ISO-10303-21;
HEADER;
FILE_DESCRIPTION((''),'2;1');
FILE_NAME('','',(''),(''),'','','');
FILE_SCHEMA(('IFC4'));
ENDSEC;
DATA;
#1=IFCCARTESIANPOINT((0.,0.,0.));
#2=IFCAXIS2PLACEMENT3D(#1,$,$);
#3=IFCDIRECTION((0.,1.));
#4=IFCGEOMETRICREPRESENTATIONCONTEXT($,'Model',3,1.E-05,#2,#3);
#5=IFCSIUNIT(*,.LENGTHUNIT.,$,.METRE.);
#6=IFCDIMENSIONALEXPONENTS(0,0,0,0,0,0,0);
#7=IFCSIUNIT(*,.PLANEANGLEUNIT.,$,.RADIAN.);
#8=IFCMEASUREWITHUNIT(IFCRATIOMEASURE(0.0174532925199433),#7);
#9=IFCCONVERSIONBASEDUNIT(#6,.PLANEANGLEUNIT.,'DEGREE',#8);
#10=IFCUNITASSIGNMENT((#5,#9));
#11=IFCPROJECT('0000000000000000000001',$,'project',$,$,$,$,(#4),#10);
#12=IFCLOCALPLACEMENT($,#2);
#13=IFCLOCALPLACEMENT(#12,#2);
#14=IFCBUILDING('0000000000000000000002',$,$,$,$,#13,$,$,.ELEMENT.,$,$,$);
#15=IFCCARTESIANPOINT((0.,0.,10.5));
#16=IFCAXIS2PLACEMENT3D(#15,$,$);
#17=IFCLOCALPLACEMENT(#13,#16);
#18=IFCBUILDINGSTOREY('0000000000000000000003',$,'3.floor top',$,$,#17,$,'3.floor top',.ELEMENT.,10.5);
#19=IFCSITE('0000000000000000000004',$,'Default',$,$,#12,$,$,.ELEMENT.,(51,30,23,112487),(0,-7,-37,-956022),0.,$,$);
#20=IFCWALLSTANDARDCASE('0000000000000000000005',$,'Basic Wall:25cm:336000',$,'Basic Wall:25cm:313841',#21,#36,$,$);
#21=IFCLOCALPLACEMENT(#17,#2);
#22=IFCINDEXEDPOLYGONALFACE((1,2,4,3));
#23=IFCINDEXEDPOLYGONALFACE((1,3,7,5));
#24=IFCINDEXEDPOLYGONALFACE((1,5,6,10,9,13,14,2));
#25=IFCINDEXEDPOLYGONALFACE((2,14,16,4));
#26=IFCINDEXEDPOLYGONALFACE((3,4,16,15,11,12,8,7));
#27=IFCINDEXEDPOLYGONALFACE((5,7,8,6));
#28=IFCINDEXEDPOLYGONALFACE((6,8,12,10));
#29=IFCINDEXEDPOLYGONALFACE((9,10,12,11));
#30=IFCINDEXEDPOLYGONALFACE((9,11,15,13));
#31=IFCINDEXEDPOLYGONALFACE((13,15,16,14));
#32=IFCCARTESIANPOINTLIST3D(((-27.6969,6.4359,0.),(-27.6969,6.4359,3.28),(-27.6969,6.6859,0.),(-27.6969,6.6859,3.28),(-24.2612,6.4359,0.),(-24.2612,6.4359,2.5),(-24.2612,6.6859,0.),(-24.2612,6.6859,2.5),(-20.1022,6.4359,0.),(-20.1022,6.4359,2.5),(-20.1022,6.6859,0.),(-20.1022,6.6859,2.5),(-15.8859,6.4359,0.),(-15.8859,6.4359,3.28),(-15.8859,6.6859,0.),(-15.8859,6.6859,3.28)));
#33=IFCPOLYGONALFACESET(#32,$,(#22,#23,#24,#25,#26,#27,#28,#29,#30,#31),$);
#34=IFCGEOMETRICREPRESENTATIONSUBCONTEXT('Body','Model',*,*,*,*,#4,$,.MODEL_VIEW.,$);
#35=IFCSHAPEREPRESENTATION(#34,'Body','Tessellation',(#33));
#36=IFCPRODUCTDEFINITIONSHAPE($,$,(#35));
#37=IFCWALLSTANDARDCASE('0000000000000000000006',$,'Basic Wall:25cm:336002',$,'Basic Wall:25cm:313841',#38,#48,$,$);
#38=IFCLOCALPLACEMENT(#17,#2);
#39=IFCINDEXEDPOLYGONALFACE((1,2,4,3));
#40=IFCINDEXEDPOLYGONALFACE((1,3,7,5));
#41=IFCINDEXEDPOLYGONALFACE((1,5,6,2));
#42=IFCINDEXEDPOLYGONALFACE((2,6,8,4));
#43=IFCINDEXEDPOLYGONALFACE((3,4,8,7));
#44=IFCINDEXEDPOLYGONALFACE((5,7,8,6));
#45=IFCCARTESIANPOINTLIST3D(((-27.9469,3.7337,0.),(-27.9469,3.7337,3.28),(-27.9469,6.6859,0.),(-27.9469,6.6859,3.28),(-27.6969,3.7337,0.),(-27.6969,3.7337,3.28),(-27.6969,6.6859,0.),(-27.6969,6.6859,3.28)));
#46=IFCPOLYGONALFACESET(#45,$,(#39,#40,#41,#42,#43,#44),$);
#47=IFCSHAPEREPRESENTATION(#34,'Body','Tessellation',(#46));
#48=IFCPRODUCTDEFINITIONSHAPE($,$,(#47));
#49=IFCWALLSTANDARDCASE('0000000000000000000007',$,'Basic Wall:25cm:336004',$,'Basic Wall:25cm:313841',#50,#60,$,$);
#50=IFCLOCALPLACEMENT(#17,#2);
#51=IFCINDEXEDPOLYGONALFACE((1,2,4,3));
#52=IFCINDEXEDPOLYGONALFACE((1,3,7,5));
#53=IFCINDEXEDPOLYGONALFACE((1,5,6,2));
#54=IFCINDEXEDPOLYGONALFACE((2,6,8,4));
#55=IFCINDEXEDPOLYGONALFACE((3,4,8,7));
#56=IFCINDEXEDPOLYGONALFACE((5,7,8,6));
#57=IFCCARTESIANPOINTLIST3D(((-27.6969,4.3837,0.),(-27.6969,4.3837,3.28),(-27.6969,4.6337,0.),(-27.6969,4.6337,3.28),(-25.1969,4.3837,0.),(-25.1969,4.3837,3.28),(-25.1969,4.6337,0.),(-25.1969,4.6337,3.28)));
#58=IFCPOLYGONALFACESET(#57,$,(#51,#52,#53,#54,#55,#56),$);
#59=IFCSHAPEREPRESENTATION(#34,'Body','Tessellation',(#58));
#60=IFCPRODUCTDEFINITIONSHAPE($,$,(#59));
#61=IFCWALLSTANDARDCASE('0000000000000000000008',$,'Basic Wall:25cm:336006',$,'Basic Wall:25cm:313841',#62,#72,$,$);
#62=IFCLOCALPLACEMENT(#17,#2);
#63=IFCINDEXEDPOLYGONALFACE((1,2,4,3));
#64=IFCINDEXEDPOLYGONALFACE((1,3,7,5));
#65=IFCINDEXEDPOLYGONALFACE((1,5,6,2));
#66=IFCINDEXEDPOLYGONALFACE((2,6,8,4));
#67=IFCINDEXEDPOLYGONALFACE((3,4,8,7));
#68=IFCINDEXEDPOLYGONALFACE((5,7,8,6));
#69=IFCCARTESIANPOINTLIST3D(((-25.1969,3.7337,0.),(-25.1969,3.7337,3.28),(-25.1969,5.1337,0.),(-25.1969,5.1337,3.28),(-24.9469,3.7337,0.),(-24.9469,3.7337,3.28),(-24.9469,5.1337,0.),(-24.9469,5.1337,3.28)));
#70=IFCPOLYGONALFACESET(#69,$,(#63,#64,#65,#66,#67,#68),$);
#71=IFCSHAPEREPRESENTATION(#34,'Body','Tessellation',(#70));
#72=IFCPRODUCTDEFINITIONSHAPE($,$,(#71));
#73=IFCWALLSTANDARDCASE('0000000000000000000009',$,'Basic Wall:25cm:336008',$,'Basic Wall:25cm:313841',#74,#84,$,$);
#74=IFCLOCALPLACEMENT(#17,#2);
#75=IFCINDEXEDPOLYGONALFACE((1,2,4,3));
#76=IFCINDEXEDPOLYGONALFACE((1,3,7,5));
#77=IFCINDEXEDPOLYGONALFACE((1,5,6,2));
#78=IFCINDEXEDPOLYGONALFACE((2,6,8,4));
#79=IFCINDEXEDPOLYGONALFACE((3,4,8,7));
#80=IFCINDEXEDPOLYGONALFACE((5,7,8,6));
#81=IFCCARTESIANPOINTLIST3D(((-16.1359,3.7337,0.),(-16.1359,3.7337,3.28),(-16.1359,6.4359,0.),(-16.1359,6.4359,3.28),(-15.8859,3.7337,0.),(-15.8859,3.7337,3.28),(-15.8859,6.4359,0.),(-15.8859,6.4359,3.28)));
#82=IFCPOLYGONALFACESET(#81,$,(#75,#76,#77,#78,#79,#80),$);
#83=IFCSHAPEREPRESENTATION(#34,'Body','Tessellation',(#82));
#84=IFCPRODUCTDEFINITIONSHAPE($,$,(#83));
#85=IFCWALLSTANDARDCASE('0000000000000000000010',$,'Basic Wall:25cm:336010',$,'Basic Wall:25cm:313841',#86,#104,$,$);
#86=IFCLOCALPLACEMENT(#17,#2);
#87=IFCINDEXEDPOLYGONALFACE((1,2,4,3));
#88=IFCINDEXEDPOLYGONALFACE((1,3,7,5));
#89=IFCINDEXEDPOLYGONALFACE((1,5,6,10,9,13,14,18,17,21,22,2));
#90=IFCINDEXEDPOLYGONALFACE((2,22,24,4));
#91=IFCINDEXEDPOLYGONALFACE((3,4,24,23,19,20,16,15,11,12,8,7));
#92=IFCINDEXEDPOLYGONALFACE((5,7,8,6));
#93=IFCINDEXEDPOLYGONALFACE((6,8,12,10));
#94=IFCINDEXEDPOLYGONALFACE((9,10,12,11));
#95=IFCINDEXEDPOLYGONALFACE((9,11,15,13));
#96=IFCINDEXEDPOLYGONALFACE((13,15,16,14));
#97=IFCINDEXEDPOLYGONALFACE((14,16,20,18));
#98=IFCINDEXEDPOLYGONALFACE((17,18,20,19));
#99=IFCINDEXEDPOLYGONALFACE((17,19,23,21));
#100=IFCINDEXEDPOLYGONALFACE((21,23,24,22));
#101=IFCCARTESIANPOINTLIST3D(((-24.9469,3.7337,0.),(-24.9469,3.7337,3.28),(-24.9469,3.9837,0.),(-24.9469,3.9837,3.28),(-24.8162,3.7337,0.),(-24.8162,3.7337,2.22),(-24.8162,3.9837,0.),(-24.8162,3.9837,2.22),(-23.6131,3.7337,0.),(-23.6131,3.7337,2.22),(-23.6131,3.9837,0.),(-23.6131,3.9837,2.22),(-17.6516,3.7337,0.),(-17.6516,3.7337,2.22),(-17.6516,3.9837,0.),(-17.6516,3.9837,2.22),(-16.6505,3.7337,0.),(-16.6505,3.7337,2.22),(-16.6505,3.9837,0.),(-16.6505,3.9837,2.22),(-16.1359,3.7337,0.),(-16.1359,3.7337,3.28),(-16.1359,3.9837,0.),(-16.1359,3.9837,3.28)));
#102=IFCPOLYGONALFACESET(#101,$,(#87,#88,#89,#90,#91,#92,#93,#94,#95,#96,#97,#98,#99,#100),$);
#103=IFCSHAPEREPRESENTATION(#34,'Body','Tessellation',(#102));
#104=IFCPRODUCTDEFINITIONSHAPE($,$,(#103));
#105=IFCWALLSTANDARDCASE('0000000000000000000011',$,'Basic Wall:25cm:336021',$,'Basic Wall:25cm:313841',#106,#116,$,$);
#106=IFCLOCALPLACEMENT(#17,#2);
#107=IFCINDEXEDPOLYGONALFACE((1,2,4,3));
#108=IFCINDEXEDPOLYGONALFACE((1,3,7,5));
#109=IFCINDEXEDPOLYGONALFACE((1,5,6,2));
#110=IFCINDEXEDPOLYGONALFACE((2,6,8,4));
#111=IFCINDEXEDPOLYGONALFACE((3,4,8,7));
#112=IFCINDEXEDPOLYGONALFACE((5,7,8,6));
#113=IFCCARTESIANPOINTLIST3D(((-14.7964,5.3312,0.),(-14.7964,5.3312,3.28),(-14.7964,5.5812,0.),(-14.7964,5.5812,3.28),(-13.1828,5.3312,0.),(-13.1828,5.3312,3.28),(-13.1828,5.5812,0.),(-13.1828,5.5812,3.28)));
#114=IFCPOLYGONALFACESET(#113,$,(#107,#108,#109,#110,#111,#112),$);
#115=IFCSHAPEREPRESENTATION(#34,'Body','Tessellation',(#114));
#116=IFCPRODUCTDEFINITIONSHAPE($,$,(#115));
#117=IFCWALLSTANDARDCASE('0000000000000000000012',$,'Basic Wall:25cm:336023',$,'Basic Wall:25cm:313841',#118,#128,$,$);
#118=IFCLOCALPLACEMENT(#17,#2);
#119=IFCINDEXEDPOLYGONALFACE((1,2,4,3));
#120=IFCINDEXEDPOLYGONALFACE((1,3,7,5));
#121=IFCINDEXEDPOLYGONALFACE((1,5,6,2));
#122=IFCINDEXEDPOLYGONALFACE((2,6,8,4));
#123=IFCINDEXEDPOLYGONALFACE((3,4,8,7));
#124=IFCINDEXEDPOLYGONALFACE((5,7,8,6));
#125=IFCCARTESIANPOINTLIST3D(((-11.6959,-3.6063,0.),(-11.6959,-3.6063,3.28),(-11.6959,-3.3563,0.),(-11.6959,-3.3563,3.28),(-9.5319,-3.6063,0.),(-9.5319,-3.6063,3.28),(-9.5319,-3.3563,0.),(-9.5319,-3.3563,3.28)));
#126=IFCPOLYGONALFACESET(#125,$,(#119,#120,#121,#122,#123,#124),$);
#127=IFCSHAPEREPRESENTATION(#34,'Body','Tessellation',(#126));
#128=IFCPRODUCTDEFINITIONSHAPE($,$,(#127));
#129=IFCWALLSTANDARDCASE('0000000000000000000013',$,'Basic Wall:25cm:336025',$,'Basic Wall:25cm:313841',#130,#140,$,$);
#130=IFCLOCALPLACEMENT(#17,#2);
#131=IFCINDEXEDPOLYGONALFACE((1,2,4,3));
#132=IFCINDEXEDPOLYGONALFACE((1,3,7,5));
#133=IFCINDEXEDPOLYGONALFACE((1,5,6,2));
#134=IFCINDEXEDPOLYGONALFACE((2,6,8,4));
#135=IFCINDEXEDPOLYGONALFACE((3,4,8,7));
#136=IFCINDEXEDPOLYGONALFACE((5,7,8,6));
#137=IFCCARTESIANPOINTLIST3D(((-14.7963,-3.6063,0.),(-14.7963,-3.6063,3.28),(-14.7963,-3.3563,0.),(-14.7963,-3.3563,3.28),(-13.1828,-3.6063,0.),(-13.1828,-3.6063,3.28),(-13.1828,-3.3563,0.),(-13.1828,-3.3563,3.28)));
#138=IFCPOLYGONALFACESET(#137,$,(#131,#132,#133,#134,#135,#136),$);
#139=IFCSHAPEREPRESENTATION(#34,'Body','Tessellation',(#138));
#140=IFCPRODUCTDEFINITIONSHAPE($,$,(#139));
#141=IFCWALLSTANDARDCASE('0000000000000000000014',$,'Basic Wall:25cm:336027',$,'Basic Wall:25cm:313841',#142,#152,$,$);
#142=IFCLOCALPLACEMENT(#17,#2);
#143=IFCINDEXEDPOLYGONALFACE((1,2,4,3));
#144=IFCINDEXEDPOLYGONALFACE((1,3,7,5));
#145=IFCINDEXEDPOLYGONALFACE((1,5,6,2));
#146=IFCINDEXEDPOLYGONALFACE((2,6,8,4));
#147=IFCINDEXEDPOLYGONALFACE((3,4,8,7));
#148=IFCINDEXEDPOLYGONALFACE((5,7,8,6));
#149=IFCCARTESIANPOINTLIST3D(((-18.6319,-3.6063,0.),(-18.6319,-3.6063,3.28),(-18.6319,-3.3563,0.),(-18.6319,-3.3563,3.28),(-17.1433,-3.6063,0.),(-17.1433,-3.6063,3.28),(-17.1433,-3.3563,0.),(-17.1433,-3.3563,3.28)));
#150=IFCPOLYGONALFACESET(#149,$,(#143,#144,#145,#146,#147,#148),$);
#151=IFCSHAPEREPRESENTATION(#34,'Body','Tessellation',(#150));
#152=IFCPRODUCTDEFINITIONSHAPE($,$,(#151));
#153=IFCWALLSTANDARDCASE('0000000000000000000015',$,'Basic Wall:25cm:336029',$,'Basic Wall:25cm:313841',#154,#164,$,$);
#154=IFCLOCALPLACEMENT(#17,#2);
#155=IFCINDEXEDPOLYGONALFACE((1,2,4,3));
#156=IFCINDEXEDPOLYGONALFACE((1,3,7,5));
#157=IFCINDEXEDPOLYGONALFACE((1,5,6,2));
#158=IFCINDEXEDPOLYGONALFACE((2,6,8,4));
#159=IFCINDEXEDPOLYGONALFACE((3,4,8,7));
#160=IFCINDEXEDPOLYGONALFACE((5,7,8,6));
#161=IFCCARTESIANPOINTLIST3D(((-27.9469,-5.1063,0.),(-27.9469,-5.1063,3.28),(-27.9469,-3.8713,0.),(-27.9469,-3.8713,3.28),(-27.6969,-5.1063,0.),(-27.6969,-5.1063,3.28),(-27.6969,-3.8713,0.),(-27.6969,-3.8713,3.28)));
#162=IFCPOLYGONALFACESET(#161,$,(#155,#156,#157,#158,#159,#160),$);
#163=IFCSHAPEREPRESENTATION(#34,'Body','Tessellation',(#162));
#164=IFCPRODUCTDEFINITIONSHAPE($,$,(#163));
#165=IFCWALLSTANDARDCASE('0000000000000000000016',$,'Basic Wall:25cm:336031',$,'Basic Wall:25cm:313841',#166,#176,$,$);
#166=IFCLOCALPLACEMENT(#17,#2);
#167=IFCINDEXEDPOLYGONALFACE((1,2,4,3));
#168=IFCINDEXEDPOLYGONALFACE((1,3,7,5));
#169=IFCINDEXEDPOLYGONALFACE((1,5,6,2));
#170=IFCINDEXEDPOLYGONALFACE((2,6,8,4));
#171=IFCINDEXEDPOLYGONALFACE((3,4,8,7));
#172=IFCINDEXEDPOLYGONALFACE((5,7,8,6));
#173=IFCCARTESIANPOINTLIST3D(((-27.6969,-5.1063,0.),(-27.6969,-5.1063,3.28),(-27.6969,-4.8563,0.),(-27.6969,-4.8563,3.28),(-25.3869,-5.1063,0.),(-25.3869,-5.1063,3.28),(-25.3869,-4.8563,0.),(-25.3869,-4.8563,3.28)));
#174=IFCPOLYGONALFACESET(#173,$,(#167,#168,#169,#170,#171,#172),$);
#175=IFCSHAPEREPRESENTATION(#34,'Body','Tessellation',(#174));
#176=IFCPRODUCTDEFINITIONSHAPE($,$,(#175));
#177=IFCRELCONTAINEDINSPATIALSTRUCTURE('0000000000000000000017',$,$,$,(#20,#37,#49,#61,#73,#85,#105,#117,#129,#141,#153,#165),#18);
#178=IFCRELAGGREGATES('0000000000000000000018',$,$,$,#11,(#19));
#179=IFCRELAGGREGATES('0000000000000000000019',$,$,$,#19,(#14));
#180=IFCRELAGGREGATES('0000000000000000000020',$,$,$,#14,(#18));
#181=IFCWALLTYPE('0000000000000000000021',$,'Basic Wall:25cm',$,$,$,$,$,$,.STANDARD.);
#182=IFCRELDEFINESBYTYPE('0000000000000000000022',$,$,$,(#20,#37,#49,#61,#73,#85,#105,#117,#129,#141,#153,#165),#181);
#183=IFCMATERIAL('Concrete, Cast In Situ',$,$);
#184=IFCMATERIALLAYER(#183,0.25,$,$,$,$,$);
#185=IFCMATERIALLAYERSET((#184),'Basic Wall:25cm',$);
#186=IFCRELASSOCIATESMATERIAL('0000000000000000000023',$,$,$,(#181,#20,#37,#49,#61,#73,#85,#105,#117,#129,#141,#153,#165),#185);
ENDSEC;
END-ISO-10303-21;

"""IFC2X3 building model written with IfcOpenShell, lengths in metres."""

from ifc_helpers import new_model, entity, si_unit, converted_unit, direction, frame, frame_2d, origin, origin_2d_with_axis, place, context, subcontext, project, spatial, rectangle, extrude, material, layer, layer_set, layer_usage, type_object, element, save


model = new_model("IFC2X3")

# Units and contexts
model_context = context("Model", 3, precision=1e-05, world=origin(), true_north=direction((0.0, 1.0)))
body_context = subcontext(model_context, "Body", "Model", "MODEL_VIEW")
ifc_project = project(units=[si_unit("LENGTHUNIT", "METRE"), converted_unit("PLANEANGLEUNIT", "DEGREE", entity("IfcRatioMeasure", 0.0174532925199433), si_unit("PLANEANGLEUNIT", "RADIAN"), dimensions=[0, 0, 0, 0, 0, 0, 0])], contexts=[model_context])

# Site, building, storey
site_placement = place(None, origin())
site = spatial("IfcSite", under=ifc_project, at=site_placement, Name="Default", CompositionType="ELEMENT", RefLatitude=(51, 30, 23, 112487), RefLongitude=(0, -7, -37, -956022), RefElevation=0.0)
building_placement = place(site_placement, origin())
building = spatial("IfcBuilding", under=site, at=building_placement, CompositionType="ELEMENT")
storey_placement = place(building_placement, frame((0.0, 0.0, 10.5)))
storey = spatial("IfcBuildingStorey", under=building, at=storey_placement, Name="3.floor top", LongName="3.floor top", CompositionType="ELEMENT", Elevation=10.5)

# Wall, opening
ifc_material = material(Name="Concrete, Cast In Situ")
ifc_layer = layer(ifc_material, 0.25)
ifc_layer_set = layer_set([ifc_layer], Name="Basic Wall:25cm")
ifc_layer_usage_1 = layer_usage(ifc_layer_set, "AXIS2", "NEGATIVE", 0.125)
wall_type = type_object("IfcWallType", Name="Basic Wall:25cm", PredefinedType="STANDARD", material=ifc_layer_set)
wall_1_placement = place(storey_placement, frame((-15.8859, 6.5609, 0.0), z_axis=(0.0, 0.0, 1.0), x_axis=(-1.0, 0.0, 0.0)))
wall_1 = element("IfcWallStandardCase", 1, at=wall_1_placement, inside=storey, type_object=wall_type, material=ifc_layer_usage_1, Name="Basic Wall:25cm:336000", ObjectType="Basic Wall:25cm:313841", context=body_context, shape_type="SweptSolid", body=[
    extrude(rectangle(XDim=11.811, YDim=0.25, at=frame_2d((5.9055, 0.0), x_axis=(-1.0, 0.0))), origin(), (0.0, 0.0, 1.0), 3.28),
])
opening_1_placement = place(wall_1_placement, origin())
element("IfcOpeningElement", 2, at=opening_1_placement, cuts=wall_1, ObjectType="Opening", context=body_context, shape_type="SweptSolid", body=[
    extrude(rectangle(XDim=2.5, YDim=4.1591, at=origin_2d_with_axis()), frame((6.2958, -0.125, 1.25), z_axis=(0.0, 1.0, 0.0), x_axis=(0.0, 0.0, -1.0)), (0.0, 0.0, 1.0), 0.25),
])

# Walls
ifc_layer_usage_2 = layer_usage(ifc_layer_set, "AXIS2", "NEGATIVE", 0.125)
wall_2_placement = place(storey_placement, frame((-27.8219, 6.6859, 0.0), z_axis=(0.0, 0.0, 1.0), x_axis=(0.0, -1.0, 0.0)))
element("IfcWallStandardCase", 3, at=wall_2_placement, inside=storey, type_object=wall_type, material=ifc_layer_usage_2, Name="Basic Wall:25cm:336002", ObjectType="Basic Wall:25cm:313841", context=body_context, shape_type="SweptSolid", body=[
    extrude(rectangle(XDim=2.9523, YDim=0.25, at=frame_2d((1.4761, 0.0), x_axis=(-1.0, 0.0))), origin(), (0.0, 0.0, 1.0), 3.28),
])
ifc_layer_usage_3 = layer_usage(ifc_layer_set, "AXIS2", "POSITIVE", -0.125)
wall_3_placement = place(storey_placement, frame((-27.6969, 4.5087, 0.0)))
element("IfcWallStandardCase", 4, at=wall_3_placement, inside=storey, type_object=wall_type, material=ifc_layer_usage_3, Name="Basic Wall:25cm:336004", ObjectType="Basic Wall:25cm:313841", context=body_context, shape_type="SweptSolid", body=[
    extrude(rectangle(XDim=2.5, YDim=0.25, at=frame_2d((1.25, 0.0), x_axis=(-1.0, 0.0))), origin(), (0.0, 0.0, 1.0), 3.28),
])
ifc_layer_usage_4 = layer_usage(ifc_layer_set, "AXIS2", "NEGATIVE", 0.125)
wall_4_placement = place(storey_placement, frame((-25.0719, 5.1337, 0.0), z_axis=(0.0, 0.0, 1.0), x_axis=(0.0, -1.0, 0.0)))
element("IfcWallStandardCase", 5, at=wall_4_placement, inside=storey, type_object=wall_type, material=ifc_layer_usage_4, Name="Basic Wall:25cm:336006", ObjectType="Basic Wall:25cm:313841", context=body_context, shape_type="SweptSolid", body=[
    extrude(rectangle(XDim=1.4, YDim=0.25, at=frame_2d((0.7, 0.0), x_axis=(-1.0, 0.0))), origin(), (0.0, 0.0, 1.0), 3.28),
])
ifc_layer_usage_5 = layer_usage(ifc_layer_set, "AXIS2", "POSITIVE", -0.125)
wall_5_placement = place(storey_placement, frame((-16.0109, 6.4359, 0.0), z_axis=(0.0, 0.0, 1.0), x_axis=(0.0, -1.0, 0.0)))
element("IfcWallStandardCase", 6, at=wall_5_placement, inside=storey, type_object=wall_type, material=ifc_layer_usage_5, Name="Basic Wall:25cm:336008", ObjectType="Basic Wall:25cm:313841", context=body_context, shape_type="SweptSolid", body=[
    extrude(rectangle(XDim=2.7022, YDim=0.25, at=frame_2d((1.3511, 0.0), x_axis=(-1.0, 0.0))), origin(), (0.0, 0.0, 1.0), 3.28),
])

# Wall, openings
ifc_layer_usage_6 = layer_usage(ifc_layer_set, "AXIS2", "POSITIVE", -0.125)
wall_6_placement = place(storey_placement, frame((-16.1359, 3.8587, 0.0), z_axis=(0.0, 0.0, 1.0), x_axis=(-1.0, -0.000001, 0.0)))
wall_6 = element("IfcWallStandardCase", 7, at=wall_6_placement, inside=storey, type_object=wall_type, material=ifc_layer_usage_6, Name="Basic Wall:25cm:336010", ObjectType="Basic Wall:25cm:313841", context=body_context, shape_type="SweptSolid", body=[
    extrude(rectangle(XDim=8.811, YDim=0.25, at=frame_2d((4.4055, 0.0), x_axis=(-1.0, 0.0))), origin(), (0.0, 0.0, 1.0), 3.28),
])
opening_2_placement = place(wall_6_placement, origin())
element("IfcOpeningElement", 8, at=opening_2_placement, cuts=wall_6, ObjectType="Opening", context=body_context, shape_type="SweptSolid", body=[
    extrude(rectangle(XDim=2.22, YDim=1.2031, at=origin_2d_with_axis()), frame((8.0788, -0.125, 1.11), z_axis=(0.0, 1.0, 0.0), x_axis=(0.0, 0.0, -1.0)), (0.0, 0.0, 1.0), 0.25),
])
opening_3_placement = place(wall_6_placement, origin())
element("IfcOpeningElement", 9, at=opening_3_placement, cuts=wall_6, ObjectType="Opening", context=body_context, shape_type="SweptSolid", body=[
    extrude(rectangle(XDim=2.22, YDim=1.0011, at=frame_2d((0.0, 0.0), x_axis=(1.0, 0.0))), frame((1.0152, -0.125, 1.11), z_axis=(0.0, 1.0, 0.0), x_axis=(0.0, 0.0, -1.0)), (0.0, 0.0, 1.0), 0.25),
])

# Walls
ifc_layer_usage_7 = layer_usage(ifc_layer_set, "AXIS2", "POSITIVE", -0.125)
wall_7_placement = place(storey_placement, frame((-14.7964, 5.4562, 0.0)))
element("IfcWallStandardCase", 10, at=wall_7_placement, inside=storey, type_object=wall_type, material=ifc_layer_usage_7, Name="Basic Wall:25cm:336021", ObjectType="Basic Wall:25cm:313841", context=body_context, shape_type="SweptSolid", body=[
    extrude(rectangle(XDim=1.6135, YDim=0.25, at=frame_2d((0.8068, 0.0), x_axis=(-1.0, 0.0))), origin(), (0.0, 0.0, 1.0), 3.28),
])
ifc_layer_usage_8 = layer_usage(ifc_layer_set, "AXIS2", "NEGATIVE", 0.125)
wall_8_placement = place(storey_placement, frame((-11.6959, -3.4813, 0.0)))
element("IfcWallStandardCase", 11, at=wall_8_placement, inside=storey, type_object=wall_type, material=ifc_layer_usage_8, Name="Basic Wall:25cm:336023", ObjectType="Basic Wall:25cm:313841", context=body_context, shape_type="SweptSolid", body=[
    extrude(rectangle(XDim=2.164, YDim=0.25, at=frame_2d((1.082, 0.0), x_axis=(-1.0, 0.0))), origin(), (0.0, 0.0, 1.0), 3.28),
])
ifc_layer_usage_9 = layer_usage(ifc_layer_set, "AXIS2", "POSITIVE", -0.125)
wall_9_placement = place(storey_placement, frame((-13.1828, -3.4813, 0.0), z_axis=(0.0, 0.0, 1.0), x_axis=(-1.0, 0.0, 0.0)))
element("IfcWallStandardCase", 12, at=wall_9_placement, inside=storey, type_object=wall_type, material=ifc_layer_usage_9, Name="Basic Wall:25cm:336025", ObjectType="Basic Wall:25cm:313841", context=body_context, shape_type="SweptSolid", body=[
    extrude(rectangle(XDim=1.6135, YDim=0.25, at=frame_2d((0.8068, 0.0), x_axis=(-1.0, 0.0))), origin(), (0.0, 0.0, 1.0), 3.28),
])
ifc_layer_usage_10 = layer_usage(ifc_layer_set, "AXIS2", "NEGATIVE", 0.125)
wall_10_placement = place(storey_placement, frame((-18.6319, -3.4813, 0.0)))
element("IfcWallStandardCase", 13, at=wall_10_placement, inside=storey, type_object=wall_type, material=ifc_layer_usage_10, Name="Basic Wall:25cm:336027", ObjectType="Basic Wall:25cm:313841", context=body_context, shape_type="SweptSolid", body=[
    extrude(rectangle(XDim=1.4886, YDim=0.25, at=frame_2d((0.7443, 0.0), x_axis=(-1.0, 0.0))), origin(), (0.0, 0.0, 1.0), 3.28),
])
ifc_layer_usage_11 = layer_usage(ifc_layer_set, "AXIS2", "NEGATIVE", 0.125)
wall_11_placement = place(storey_placement, frame((-27.8219, -3.8713, 0.0), z_axis=(0.0, 0.0, 1.0), x_axis=(0.0, -1.0, 0.0)))
element("IfcWallStandardCase", 14, at=wall_11_placement, inside=storey, type_object=wall_type, material=ifc_layer_usage_11, Name="Basic Wall:25cm:336029", ObjectType="Basic Wall:25cm:313841", context=body_context, shape_type="SweptSolid", body=[
    extrude(rectangle(XDim=1.235, YDim=0.25, at=frame_2d((0.6175, 0.0), x_axis=(-1.0, 0.0))), origin(), (0.0, 0.0, 1.0), 3.28),
])
ifc_layer_usage_12 = layer_usage(ifc_layer_set, "AXIS2", "NEGATIVE", 0.125)
wall_12_placement = place(storey_placement, frame((-27.6969, -4.9813, 0.0)))
element("IfcWallStandardCase", 15, at=wall_12_placement, inside=storey, type_object=wall_type, material=ifc_layer_usage_12, Name="Basic Wall:25cm:336031", ObjectType="Basic Wall:25cm:313841", context=body_context, shape_type="SweptSolid", body=[
    extrude(rectangle(XDim=2.31, YDim=0.25, at=frame_2d((1.155, 0.0), x_axis=(-1.0, 0.0))), origin(), (0.0, 0.0, 1.0), 3.28),
])

save(model, "model.ifc")
